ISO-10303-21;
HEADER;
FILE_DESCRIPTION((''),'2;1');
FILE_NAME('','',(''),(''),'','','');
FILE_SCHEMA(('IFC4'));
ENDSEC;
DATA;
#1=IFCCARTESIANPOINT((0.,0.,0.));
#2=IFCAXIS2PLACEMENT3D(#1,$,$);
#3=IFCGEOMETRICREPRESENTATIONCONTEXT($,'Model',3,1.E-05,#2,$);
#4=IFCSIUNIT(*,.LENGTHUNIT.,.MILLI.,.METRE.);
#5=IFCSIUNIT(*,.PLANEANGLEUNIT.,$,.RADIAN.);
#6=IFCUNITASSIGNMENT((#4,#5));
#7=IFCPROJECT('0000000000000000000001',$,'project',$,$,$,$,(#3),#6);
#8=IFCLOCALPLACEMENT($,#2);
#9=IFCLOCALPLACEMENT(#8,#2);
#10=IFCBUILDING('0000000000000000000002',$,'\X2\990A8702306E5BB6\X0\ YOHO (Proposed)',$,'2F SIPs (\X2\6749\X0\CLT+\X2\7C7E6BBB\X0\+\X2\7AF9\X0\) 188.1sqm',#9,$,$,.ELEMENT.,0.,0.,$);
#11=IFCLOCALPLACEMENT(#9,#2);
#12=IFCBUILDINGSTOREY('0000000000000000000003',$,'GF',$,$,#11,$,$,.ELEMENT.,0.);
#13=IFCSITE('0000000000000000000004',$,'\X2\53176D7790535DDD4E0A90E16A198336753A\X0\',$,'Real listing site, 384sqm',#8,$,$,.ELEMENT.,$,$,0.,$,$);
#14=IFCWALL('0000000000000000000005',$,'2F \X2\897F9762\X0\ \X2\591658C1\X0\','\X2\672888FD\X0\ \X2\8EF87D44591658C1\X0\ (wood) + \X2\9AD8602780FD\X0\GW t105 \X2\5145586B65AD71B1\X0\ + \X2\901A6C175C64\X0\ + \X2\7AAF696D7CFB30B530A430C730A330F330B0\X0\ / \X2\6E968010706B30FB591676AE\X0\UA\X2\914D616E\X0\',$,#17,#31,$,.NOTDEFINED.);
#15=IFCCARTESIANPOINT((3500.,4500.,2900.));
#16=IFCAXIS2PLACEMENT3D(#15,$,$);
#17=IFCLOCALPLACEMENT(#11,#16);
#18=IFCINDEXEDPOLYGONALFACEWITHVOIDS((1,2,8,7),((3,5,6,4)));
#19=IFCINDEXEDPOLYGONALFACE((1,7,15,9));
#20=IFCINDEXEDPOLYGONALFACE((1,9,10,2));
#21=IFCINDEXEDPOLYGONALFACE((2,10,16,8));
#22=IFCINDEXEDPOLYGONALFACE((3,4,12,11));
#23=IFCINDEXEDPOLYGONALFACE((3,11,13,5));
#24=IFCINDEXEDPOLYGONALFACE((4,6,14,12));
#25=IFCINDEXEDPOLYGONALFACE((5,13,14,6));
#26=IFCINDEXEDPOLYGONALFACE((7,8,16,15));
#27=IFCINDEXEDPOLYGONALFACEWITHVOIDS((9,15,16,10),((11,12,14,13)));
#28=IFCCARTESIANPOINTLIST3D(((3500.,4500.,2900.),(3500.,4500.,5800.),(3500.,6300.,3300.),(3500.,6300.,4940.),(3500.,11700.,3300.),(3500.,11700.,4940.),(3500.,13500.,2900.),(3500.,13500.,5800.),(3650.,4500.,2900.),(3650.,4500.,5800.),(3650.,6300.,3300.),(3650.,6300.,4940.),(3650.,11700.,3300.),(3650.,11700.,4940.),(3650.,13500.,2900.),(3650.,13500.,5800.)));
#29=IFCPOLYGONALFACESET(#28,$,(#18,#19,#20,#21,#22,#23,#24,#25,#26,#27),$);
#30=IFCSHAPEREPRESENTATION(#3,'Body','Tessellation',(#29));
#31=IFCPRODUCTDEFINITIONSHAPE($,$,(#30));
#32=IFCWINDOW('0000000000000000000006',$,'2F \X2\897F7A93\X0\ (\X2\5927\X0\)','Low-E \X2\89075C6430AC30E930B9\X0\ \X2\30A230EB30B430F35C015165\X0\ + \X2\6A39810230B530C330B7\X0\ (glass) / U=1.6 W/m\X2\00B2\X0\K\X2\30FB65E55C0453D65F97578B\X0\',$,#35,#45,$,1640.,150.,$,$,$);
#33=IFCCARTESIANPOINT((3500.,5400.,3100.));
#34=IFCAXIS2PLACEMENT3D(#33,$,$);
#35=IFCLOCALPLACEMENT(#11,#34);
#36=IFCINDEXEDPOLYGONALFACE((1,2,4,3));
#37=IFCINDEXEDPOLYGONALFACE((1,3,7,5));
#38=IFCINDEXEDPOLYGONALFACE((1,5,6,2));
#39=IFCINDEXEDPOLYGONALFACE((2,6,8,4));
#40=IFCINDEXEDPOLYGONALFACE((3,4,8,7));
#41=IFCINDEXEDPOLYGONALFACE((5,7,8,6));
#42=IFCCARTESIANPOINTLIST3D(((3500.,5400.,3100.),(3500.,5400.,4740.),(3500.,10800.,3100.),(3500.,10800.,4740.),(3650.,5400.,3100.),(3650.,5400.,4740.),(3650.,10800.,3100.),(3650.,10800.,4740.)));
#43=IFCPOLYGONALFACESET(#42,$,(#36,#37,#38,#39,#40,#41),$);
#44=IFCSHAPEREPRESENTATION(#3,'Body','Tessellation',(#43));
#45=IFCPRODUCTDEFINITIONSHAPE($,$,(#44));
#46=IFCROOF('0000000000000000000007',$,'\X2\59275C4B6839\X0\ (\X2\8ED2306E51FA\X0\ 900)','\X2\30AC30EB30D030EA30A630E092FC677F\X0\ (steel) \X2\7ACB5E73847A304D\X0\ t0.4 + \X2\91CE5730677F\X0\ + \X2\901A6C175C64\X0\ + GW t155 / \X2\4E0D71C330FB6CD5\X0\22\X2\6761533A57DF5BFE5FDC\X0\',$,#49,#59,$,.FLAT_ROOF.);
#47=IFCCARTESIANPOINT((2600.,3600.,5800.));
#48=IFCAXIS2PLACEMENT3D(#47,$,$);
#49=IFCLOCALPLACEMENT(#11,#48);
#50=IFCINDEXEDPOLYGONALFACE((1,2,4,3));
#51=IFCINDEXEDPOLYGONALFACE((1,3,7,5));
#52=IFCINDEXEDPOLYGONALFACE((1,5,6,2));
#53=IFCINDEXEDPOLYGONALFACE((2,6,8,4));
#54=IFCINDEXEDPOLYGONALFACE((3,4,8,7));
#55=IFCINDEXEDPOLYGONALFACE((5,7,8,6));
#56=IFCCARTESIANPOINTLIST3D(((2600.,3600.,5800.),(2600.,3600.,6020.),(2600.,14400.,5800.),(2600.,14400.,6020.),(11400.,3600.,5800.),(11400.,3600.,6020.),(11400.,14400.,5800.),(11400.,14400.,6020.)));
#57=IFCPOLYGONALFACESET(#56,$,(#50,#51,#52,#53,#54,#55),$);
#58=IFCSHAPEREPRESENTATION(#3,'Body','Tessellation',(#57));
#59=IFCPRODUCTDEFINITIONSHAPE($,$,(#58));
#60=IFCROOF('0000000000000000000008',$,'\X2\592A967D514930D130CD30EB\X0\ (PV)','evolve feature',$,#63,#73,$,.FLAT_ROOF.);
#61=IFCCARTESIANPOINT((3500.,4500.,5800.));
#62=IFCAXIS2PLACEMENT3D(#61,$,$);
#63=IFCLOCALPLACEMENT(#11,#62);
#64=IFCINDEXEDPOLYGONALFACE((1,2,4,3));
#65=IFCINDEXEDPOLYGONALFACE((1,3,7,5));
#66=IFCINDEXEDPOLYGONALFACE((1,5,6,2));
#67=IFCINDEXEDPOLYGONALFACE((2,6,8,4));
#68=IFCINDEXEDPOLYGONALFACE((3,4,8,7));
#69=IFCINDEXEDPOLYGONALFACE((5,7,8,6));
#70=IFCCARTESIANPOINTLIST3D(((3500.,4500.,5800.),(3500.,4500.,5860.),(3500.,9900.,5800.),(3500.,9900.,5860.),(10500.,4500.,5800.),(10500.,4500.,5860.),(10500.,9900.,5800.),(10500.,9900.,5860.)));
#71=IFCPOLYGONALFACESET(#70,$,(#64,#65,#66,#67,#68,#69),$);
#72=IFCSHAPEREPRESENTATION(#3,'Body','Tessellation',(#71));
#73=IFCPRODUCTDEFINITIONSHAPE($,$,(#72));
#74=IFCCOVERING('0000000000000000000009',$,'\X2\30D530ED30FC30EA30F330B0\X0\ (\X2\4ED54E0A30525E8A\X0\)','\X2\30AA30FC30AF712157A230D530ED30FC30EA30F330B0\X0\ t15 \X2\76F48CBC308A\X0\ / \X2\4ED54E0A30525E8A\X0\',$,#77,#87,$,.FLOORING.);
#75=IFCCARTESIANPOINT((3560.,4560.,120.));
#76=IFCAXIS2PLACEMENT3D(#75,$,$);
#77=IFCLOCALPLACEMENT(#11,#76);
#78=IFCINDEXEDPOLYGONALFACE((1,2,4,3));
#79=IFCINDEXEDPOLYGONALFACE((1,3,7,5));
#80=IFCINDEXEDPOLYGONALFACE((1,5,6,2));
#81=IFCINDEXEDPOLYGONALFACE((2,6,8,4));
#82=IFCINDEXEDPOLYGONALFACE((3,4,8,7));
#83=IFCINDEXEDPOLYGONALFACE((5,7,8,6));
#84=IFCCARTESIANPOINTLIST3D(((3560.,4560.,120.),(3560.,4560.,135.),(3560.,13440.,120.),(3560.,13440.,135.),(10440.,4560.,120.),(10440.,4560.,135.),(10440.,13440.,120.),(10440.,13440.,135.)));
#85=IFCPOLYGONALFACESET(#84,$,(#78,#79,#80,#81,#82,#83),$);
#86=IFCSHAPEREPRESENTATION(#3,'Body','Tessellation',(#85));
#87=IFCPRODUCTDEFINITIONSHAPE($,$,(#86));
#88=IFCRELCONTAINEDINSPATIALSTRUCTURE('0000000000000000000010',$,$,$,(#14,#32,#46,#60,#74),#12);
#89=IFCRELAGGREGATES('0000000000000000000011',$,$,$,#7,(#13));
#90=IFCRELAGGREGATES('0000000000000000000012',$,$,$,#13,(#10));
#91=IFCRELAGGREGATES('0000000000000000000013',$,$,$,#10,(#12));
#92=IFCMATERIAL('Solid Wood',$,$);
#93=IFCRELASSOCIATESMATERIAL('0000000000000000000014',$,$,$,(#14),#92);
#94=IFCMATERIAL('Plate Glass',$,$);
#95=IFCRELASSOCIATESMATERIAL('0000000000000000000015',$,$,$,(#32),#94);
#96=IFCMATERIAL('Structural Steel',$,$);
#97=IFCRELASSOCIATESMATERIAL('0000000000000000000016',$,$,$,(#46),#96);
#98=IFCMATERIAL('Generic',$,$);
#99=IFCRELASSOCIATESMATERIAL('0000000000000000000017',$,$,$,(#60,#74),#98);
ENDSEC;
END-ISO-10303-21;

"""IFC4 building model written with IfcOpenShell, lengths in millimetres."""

from ifc_helpers import new_model, si_unit, frame, frame_2d, origin, place, context, project, spatial, rectangle, extrude, material, element, fill, save


model = new_model("IFC4")

# Units and contexts
model_context = context("Model", 3, precision=1e-05, world=origin())
ifc_project = project(units=[si_unit("LENGTHUNIT", "METRE", prefix="MILLI"), si_unit("PLANEANGLEUNIT", "RADIAN")], contexts=[model_context])

# Site, building, storey
site_placement = place(None, origin())
site = spatial("IfcSite", under=ifc_project, at=site_placement, Name="北海道川上郡標茶町", ObjectType="Real listing site, 384sqm", CompositionType="ELEMENT", RefElevation=0.0)
building_placement = place(site_placement, origin())
building = spatial("IfcBuilding", under=site, at=building_placement, Name="養蜂の家 YOHO (Proposed)", ObjectType="2F SIPs (杉CLT+籾殻+竹) 188.1sqm", CompositionType="ELEMENT", ElevationOfRefHeight=0.0, ElevationOfTerrain=0.0)
storey_placement = place(building_placement, origin())
storey = spatial("IfcBuildingStorey", under=building, at=storey_placement, Name="GF", CompositionType="ELEMENT", Elevation=0.0)

# Shared definitions
ifc_material_1 = material(Name="Solid Wood")

# Shared definitions
ifc_material_2 = material(Name="Plate Glass")
ifc_material_3 = material(Name="Generic")

# Wall, opening, window
wall_1_placement = place(storey_placement, frame((3500.0, 4500.0, 2900.0)))
wall_1 = element("IfcWall", 1, at=wall_1_placement, inside=storey, material=ifc_material_1, Name="2F 西面 外壁", Description="木製 軸組外壁 (wood) + 高性能GW t105 充填断熱 + 通気層 + 窯業系サイディング / 準耐火・外皮UA配慮", PredefinedType="NOTDEFINED", context=model_context, shape_type="SweptSolid", body=[
    extrude(rectangle(XDim=150.0, YDim=9000.0, at=frame_2d((75.0, 4500.0))), frame((3500.0, 4500.0, 2900.0)), (0.0, 0.0, 1.0), 2900.0),
])
opening_1_placement = place(storey_placement, frame((3500.0, 5400.0, 3100.0)))
opening_1 = element("IfcOpeningElement", 2, at=opening_1_placement, cuts=wall_1, PredefinedType="NOTDEFINED", context=model_context, shape_type="SweptSolid", body=[
    extrude(rectangle(XDim=150.0, YDim=5400.0, at=frame_2d((75.0, 2700.0))), frame((3500.0, 5400.0, 3100.0)), (0.0, 0.0, 1.0), 1640.0),
])
window_1_placement = place(storey_placement, frame((3500.0, 5400.0, 3100.0)))
window_1 = element("IfcWindow", 3, at=window_1_placement, inside=storey, material=ifc_material_2, Name="2F 西窓 (大)", Description="Low-E 複層ガラス アルゴン封入 + 樹脂サッシ (glass) / U=1.6 W/m²K・日射取得型", OverallHeight=1640.0, OverallWidth=150.0, context=model_context, shape_type="SweptSolid", body=[
    extrude(rectangle(XDim=150.0, YDim=5400.0, at=frame_2d((75.0, 2700.0))), frame((3500.0, 5400.0, 3100.0)), (0.0, 0.0, 1.0), 1640.0),
])
fill(opening_1, window_1)

# Roofs
ifc_material_4 = material(Name="Structural Steel")
roof_1_placement = place(storey_placement, frame((2600.0, 3600.0, 5800.0)))
element("IfcRoof", 4, at=roof_1_placement, inside=storey, material=ifc_material_4, Name="大屋根 (軒の出 900)", Description="ガルバリウム鋼板 (steel) 立平葺き t0.4 + 野地板 + 通気層 + GW t155 / 不燃・法22条区域対応", PredefinedType="FLAT_ROOF", context=model_context, shape_type="SweptSolid", body=[
    extrude(rectangle(XDim=8800.0, YDim=10800.0, at=frame_2d((4400.0, 5400.0))), frame((2600.0, 3600.0, 5800.0)), (0.0, 0.0, 1.0), 220.0),
])
roof_2_placement = place(storey_placement, frame((3500.0, 4500.0, 5800.0)))
element("IfcRoof", 5, at=roof_2_placement, inside=storey, material=ifc_material_3, Name="太陽光パネル (PV)", Description="evolve feature", PredefinedType="FLAT_ROOF", context=model_context, shape_type="SweptSolid", body=[
    extrude(rectangle(XDim=7000.0, YDim=5400.0, at=frame_2d((3500.0, 2700.0))), frame((3500.0, 4500.0, 5800.0)), (0.0, 0.0, 1.0), 60.0),
])

# Covering
covering_placement = place(storey_placement, frame((3560.0, 4560.0, 120.0)))
element("IfcCovering", 6, at=covering_placement, inside=storey, material=ifc_material_3, Name="フローリング (仕上げ床)", Description="オーク無垢フローリング t15 直貼り / 仕上げ床", PredefinedType="FLOORING", context=model_context, shape_type="SweptSolid", body=[
    extrude(rectangle(XDim=6880.0, YDim=8880.0, at=frame_2d((3440.0, 4440.0))), frame((3560.0, 4560.0, 120.0)), (0.0, 0.0, 1.0), 15.0),
])

save(model, "model.ifc")
